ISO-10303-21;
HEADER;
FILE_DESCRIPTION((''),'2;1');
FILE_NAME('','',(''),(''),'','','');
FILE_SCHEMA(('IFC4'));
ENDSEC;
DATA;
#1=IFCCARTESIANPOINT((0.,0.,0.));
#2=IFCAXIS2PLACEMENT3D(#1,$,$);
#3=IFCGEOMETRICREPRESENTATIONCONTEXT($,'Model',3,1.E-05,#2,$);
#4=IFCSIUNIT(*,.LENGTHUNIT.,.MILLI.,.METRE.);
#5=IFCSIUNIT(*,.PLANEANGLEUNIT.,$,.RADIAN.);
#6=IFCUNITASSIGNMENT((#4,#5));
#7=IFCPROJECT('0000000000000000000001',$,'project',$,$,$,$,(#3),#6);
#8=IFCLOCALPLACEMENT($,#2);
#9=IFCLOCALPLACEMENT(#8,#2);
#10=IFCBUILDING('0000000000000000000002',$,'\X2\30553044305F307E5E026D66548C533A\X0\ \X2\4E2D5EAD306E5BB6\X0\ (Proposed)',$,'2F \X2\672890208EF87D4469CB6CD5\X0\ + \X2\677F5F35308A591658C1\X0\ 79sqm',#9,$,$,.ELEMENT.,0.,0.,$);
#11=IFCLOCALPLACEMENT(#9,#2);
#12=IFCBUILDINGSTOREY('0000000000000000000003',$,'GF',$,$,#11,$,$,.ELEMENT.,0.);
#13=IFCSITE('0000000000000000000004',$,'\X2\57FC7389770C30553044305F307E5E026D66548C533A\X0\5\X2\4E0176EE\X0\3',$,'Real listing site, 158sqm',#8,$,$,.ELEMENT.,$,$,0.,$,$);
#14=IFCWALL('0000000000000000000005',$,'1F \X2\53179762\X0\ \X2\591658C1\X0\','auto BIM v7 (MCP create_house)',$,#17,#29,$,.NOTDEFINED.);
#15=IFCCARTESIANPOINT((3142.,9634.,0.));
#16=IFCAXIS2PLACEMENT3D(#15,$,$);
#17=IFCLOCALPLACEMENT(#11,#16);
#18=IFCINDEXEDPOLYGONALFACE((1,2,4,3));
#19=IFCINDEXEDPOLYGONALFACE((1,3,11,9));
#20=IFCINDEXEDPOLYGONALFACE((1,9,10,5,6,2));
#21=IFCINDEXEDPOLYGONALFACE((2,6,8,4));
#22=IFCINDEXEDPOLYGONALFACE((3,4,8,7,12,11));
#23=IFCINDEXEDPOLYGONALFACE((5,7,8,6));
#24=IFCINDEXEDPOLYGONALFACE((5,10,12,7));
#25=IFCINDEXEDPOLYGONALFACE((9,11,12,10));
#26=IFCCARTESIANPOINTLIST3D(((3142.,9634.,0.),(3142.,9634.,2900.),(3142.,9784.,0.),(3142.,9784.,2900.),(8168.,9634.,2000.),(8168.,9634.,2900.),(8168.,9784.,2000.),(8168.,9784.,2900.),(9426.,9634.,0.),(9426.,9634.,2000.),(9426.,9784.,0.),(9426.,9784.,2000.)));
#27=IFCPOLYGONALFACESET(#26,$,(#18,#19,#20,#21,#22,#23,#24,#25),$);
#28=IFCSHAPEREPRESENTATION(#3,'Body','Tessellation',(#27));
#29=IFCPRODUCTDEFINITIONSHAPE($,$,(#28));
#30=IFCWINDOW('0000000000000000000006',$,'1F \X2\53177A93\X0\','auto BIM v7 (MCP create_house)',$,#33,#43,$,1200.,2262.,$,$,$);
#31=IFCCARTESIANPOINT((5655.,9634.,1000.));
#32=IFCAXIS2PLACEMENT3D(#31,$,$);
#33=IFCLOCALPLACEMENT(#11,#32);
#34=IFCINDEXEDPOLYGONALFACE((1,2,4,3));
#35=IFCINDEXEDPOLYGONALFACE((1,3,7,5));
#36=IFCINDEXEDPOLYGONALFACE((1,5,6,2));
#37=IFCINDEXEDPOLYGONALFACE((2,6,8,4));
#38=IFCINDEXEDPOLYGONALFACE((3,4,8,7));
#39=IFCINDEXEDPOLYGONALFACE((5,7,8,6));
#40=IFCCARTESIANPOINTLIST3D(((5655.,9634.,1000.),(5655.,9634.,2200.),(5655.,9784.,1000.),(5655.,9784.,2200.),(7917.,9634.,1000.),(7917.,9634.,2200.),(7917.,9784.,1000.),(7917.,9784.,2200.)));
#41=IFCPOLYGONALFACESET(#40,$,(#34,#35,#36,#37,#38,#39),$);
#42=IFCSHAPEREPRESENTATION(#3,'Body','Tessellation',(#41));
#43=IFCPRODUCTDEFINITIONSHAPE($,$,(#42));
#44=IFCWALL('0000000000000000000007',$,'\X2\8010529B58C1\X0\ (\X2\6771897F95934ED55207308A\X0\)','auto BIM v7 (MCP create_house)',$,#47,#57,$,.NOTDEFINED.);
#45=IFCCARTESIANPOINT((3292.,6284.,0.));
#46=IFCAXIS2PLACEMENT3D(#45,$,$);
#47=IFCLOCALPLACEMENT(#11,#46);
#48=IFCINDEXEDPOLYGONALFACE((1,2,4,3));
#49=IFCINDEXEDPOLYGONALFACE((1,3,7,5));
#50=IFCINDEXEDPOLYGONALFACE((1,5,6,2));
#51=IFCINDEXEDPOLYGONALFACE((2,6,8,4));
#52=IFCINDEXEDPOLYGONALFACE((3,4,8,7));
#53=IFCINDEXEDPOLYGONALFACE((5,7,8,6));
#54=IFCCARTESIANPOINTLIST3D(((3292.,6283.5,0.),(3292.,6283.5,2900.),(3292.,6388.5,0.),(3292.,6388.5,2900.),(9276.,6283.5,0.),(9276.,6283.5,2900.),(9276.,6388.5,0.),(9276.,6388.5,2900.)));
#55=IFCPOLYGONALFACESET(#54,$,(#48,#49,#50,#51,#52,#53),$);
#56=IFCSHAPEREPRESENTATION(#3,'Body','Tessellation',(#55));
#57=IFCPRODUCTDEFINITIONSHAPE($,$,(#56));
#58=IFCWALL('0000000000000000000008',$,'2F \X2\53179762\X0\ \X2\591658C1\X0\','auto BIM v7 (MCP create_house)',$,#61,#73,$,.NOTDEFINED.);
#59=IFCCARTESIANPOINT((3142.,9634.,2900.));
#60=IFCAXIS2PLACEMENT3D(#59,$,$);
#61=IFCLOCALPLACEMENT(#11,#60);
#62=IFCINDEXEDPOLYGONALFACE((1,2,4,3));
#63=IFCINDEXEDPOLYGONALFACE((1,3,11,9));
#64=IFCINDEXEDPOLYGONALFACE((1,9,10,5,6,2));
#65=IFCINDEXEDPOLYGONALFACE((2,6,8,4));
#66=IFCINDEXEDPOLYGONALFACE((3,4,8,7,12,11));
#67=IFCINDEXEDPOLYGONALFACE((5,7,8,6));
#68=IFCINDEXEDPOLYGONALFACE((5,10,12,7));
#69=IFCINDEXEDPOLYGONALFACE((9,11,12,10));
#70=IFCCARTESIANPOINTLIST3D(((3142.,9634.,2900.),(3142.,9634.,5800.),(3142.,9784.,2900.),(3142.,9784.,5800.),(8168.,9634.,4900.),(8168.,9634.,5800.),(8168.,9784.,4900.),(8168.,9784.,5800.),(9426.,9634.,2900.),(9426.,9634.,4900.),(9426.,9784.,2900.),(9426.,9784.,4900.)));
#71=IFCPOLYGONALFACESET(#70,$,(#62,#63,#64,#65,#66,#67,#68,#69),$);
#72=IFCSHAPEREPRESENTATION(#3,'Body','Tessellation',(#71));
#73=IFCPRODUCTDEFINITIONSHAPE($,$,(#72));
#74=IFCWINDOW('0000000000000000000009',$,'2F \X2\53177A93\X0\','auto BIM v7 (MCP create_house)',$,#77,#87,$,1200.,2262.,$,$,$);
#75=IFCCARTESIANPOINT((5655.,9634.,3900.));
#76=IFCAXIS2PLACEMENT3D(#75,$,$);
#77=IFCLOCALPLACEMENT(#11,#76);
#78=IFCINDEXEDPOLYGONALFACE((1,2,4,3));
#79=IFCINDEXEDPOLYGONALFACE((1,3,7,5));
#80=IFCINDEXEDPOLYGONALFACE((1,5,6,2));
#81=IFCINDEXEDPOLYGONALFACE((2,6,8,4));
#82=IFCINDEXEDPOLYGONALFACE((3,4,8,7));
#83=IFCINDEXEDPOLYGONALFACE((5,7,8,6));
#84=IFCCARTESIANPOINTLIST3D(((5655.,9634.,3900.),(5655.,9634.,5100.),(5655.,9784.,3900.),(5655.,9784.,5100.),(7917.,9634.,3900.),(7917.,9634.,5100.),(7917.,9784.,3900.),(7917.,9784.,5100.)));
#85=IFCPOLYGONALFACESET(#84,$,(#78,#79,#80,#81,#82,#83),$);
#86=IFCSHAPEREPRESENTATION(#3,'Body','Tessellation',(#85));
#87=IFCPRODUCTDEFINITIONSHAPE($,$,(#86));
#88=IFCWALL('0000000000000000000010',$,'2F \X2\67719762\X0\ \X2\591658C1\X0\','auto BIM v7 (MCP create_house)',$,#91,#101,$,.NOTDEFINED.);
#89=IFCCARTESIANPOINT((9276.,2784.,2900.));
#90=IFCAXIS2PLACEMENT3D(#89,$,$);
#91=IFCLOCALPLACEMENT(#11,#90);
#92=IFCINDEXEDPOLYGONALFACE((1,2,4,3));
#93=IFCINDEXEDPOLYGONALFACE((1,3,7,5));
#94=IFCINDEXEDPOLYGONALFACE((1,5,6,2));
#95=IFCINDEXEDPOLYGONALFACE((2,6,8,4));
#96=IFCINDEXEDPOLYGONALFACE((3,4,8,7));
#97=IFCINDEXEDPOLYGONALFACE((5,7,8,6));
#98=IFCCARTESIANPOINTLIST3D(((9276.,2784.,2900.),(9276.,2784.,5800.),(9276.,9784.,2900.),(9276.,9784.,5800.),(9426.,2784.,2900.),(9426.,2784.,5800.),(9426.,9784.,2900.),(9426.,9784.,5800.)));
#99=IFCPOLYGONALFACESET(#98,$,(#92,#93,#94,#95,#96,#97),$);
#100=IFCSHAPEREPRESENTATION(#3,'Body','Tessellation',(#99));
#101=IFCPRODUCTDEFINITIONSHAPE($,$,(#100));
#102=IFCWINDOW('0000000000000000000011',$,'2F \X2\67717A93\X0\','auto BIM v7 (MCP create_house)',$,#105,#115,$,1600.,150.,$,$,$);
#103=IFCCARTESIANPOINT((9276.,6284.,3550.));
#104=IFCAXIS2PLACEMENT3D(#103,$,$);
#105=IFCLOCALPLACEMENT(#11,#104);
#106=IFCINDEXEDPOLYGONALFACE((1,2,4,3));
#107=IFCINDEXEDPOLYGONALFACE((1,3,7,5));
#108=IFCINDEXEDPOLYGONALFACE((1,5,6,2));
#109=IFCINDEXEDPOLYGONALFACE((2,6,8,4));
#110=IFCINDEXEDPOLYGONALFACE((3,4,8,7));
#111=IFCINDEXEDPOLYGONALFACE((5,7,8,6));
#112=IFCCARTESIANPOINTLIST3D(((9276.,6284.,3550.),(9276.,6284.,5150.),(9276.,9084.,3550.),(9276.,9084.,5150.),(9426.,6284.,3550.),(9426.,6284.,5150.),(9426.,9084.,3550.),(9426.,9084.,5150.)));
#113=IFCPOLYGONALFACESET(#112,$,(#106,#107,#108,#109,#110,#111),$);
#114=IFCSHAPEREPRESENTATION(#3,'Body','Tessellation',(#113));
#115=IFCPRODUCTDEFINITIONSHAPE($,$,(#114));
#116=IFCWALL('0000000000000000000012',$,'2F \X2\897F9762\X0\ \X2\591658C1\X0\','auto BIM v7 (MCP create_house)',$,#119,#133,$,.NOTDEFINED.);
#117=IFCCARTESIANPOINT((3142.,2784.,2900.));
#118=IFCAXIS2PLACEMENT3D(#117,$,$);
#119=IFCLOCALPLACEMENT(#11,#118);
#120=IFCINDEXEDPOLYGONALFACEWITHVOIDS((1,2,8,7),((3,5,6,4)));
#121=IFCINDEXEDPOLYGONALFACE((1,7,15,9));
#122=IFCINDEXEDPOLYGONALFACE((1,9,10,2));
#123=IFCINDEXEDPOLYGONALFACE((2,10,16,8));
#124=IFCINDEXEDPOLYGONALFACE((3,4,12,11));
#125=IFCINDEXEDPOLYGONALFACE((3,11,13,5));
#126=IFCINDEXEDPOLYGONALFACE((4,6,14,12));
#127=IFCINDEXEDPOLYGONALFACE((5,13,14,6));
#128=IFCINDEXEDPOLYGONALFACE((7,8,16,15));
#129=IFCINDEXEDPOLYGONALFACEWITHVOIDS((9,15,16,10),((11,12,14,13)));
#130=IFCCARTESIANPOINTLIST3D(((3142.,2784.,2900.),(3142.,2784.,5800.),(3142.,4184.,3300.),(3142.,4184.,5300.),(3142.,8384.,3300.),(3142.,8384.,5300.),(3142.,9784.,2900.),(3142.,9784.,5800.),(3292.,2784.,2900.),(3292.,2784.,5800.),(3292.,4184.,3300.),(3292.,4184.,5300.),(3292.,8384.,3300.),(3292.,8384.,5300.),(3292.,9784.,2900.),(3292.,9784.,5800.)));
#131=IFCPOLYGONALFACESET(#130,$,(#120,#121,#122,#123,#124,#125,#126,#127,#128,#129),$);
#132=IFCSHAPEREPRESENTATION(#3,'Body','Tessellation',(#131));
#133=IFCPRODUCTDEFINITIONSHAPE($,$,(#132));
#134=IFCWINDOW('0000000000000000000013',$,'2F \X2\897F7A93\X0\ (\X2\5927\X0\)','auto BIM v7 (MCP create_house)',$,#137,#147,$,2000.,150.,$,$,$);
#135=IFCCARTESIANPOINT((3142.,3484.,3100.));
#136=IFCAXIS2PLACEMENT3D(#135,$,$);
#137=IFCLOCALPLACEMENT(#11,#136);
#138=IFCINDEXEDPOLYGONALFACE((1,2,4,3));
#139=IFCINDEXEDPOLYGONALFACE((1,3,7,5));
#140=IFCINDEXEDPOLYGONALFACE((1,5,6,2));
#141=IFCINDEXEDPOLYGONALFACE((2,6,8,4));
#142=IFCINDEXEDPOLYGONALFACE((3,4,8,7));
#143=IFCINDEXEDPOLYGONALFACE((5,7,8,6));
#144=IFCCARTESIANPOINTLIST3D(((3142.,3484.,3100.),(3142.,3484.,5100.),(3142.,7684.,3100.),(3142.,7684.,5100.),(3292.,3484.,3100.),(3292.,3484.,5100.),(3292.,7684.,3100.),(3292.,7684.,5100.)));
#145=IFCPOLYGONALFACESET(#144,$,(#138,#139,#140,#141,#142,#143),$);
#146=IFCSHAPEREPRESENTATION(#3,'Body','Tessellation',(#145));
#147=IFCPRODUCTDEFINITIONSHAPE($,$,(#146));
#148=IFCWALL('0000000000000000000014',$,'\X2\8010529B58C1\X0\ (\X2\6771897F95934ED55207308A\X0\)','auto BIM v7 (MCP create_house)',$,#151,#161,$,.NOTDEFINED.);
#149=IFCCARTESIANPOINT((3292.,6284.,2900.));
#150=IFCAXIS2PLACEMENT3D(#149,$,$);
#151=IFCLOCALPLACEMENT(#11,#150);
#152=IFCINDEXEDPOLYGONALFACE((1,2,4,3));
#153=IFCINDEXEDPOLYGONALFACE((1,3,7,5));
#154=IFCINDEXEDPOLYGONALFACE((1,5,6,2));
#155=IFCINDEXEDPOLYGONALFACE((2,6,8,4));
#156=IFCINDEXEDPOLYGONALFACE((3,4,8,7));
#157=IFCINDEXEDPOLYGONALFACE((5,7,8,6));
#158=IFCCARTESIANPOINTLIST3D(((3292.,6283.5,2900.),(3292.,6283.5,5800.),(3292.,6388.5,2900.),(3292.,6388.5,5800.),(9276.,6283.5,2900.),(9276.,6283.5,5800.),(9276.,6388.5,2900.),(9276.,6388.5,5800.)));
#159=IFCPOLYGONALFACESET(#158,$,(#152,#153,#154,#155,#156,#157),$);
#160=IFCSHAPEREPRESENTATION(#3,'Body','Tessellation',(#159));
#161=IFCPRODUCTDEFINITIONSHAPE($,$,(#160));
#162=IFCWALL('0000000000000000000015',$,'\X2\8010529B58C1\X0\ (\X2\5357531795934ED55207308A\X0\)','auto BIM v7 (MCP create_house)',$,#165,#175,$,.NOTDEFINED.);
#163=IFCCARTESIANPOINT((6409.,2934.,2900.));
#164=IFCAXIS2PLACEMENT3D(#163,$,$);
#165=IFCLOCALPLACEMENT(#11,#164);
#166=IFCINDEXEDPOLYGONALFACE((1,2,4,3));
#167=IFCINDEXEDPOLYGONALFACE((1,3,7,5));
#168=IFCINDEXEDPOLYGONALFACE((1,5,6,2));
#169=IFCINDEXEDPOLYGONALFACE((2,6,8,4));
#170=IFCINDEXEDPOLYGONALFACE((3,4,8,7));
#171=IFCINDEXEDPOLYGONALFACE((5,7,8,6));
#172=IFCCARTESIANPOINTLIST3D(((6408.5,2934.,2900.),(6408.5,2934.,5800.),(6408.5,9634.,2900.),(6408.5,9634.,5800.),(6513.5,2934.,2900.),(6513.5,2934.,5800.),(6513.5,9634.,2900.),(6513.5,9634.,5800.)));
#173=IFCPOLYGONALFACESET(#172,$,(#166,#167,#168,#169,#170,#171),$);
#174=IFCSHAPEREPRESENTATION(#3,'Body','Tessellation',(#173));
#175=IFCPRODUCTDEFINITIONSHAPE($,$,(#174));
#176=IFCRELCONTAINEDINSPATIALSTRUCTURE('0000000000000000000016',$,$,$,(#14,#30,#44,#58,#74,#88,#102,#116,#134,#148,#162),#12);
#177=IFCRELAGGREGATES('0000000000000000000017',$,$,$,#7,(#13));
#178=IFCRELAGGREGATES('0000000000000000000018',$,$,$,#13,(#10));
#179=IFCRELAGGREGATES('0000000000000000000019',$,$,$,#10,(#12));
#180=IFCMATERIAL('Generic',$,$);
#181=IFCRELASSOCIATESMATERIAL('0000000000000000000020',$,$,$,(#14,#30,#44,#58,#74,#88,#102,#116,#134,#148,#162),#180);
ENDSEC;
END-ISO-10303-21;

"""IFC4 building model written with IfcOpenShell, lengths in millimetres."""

from ifc_helpers import new_model, si_unit, frame, frame_2d, origin, place, context, project, spatial, rectangle, extrude, material, element, fill, save


model = new_model("IFC4")

# Units and contexts
model_context = context("Model", 3, precision=1e-05, world=origin())
ifc_project = project(units=[si_unit("LENGTHUNIT", "METRE", prefix="MILLI"), si_unit("PLANEANGLEUNIT", "RADIAN")], contexts=[model_context])

# Site, building, storey
site_placement = place(None, origin())
site = spatial("IfcSite", under=ifc_project, at=site_placement, Name="埼玉県さいたま市浦和区5丁目3", ObjectType="Real listing site, 158sqm", CompositionType="ELEMENT", RefElevation=0.0)
building_placement = place(site_placement, origin())
building = spatial("IfcBuilding", under=site, at=building_placement, Name="さいたま市浦和区 中庭の家 (Proposed)", ObjectType="2F 木造軸組構法 + 板張り外壁 79sqm", CompositionType="ELEMENT", ElevationOfRefHeight=0.0, ElevationOfTerrain=0.0)
storey_placement = place(building_placement, origin())
storey = spatial("IfcBuildingStorey", under=building, at=storey_placement, Name="GF", CompositionType="ELEMENT", Elevation=0.0)

# Wall, opening, window
ifc_material = material(Name="Generic")
wall_1_placement = place(storey_placement, frame((3142.0, 9634.0, 0.0)))
wall_1 = element("IfcWall", 1, at=wall_1_placement, inside=storey, material=ifc_material, Name="1F 北面 外壁", Description="auto BIM v7 (MCP create_house)", PredefinedType="NOTDEFINED", context=model_context, shape_type="SweptSolid", body=[
    extrude(rectangle(XDim=6284.0, YDim=150.0, at=frame_2d((3142.0, 75.0))), frame((3142.0, 9634.0, 0.0)), (0.0, 0.0, 1.0), 2900.0),
])
opening_1_placement = place(storey_placement, frame((5655.0, 9634.0, 1000.0)))
opening_1 = element("IfcOpeningElement", 2, at=opening_1_placement, cuts=wall_1, PredefinedType="NOTDEFINED", context=model_context, shape_type="SweptSolid", body=[
    extrude(rectangle(XDim=2262.0, YDim=150.0, at=frame_2d((1131.0, 75.0))), frame((5655.0, 9634.0, 1000.0)), (0.0, 0.0, 1.0), 1200.0),
])
window_1_placement = place(storey_placement, frame((5655.0, 9634.0, 1000.0)))
window_1 = element("IfcWindow", 3, at=window_1_placement, inside=storey, material=ifc_material, Name="1F 北窓", Description="auto BIM v7 (MCP create_house)", OverallHeight=1200.0, OverallWidth=2262.0, context=model_context, shape_type="SweptSolid", body=[
    extrude(rectangle(XDim=2262.0, YDim=150.0, at=frame_2d((1131.0, 75.0))), frame((5655.0, 9634.0, 1000.0)), (0.0, 0.0, 1.0), 1200.0),
])
fill(opening_1, window_1)

# Wall
wall_2_placement = place(storey_placement, frame((3292.0, 6284.0, 0.0)))
element("IfcWall", 4, at=wall_2_placement, inside=storey, material=ifc_material, Name="耐力壁 (東西間仕切り)", Description="auto BIM v7 (MCP create_house)", PredefinedType="NOTDEFINED", context=model_context, shape_type="SweptSolid", body=[
    extrude(rectangle(XDim=5984.0, YDim=105.0, at=frame_2d((2992.0, 52.0))), frame((3292.0, 6284.0, 0.0)), (0.0, 0.0, 1.0), 2900.0),
])

# Walls, openings, windows
wall_3_placement = place(storey_placement, frame((3142.0, 9634.0, 2900.0)))
wall_3 = element("IfcWall", 5, at=wall_3_placement, inside=storey, material=ifc_material, Name="2F 北面 外壁", Description="auto BIM v7 (MCP create_house)", PredefinedType="NOTDEFINED", context=model_context, shape_type="SweptSolid", body=[
    extrude(rectangle(XDim=6284.0, YDim=150.0, at=frame_2d((3142.0, 75.0))), frame((3142.0, 9634.0, 2900.0)), (0.0, 0.0, 1.0), 2900.0),
])
opening_2_placement = place(storey_placement, frame((5655.0, 9634.0, 3900.0)))
opening_2 = element("IfcOpeningElement", 6, at=opening_2_placement, cuts=wall_3, PredefinedType="NOTDEFINED", context=model_context, shape_type="SweptSolid", body=[
    extrude(rectangle(XDim=2262.0, YDim=150.0, at=frame_2d((1131.0, 75.0))), frame((5655.0, 9634.0, 3900.0)), (0.0, 0.0, 1.0), 1200.0),
])
window_2_placement = place(storey_placement, frame((5655.0, 9634.0, 3900.0)))
window_2 = element("IfcWindow", 7, at=window_2_placement, inside=storey, material=ifc_material, Name="2F 北窓", Description="auto BIM v7 (MCP create_house)", OverallHeight=1200.0, OverallWidth=2262.0, context=model_context, shape_type="SweptSolid", body=[
    extrude(rectangle(XDim=2262.0, YDim=150.0, at=frame_2d((1131.0, 75.0))), frame((5655.0, 9634.0, 3900.0)), (0.0, 0.0, 1.0), 1200.0),
])
fill(opening_2, window_2)
wall_4_placement = place(storey_placement, frame((9276.0, 2784.0, 2900.0)))
wall_4 = element("IfcWall", 8, at=wall_4_placement, inside=storey, material=ifc_material, Name="2F 東面 外壁", Description="auto BIM v7 (MCP create_house)", PredefinedType="NOTDEFINED", context=model_context, shape_type="SweptSolid", body=[
    extrude(rectangle(XDim=150.0, YDim=7000.0, at=frame_2d((75.0, 3500.0))), frame((9276.0, 2784.0, 2900.0)), (0.0, 0.0, 1.0), 2900.0),
])
opening_3_placement = place(storey_placement, frame((9276.0, 6284.0, 3550.0)))
opening_3 = element("IfcOpeningElement", 9, at=opening_3_placement, cuts=wall_4, PredefinedType="NOTDEFINED", context=model_context, shape_type="SweptSolid", body=[
    extrude(rectangle(XDim=150.0, YDim=2800.0, at=frame_2d((75.0, 1400.0))), frame((9276.0, 6284.0, 3550.0)), (0.0, 0.0, 1.0), 1600.0),
])
window_3_placement = place(storey_placement, frame((9276.0, 6284.0, 3550.0)))
window_3 = element("IfcWindow", 10, at=window_3_placement, inside=storey, material=ifc_material, Name="2F 東窓", Description="auto BIM v7 (MCP create_house)", OverallHeight=1600.0, OverallWidth=150.0, context=model_context, shape_type="SweptSolid", body=[
    extrude(rectangle(XDim=150.0, YDim=2800.0, at=frame_2d((75.0, 1400.0))), frame((9276.0, 6284.0, 3550.0)), (0.0, 0.0, 1.0), 1600.0),
])
fill(opening_3, window_3)
wall_5_placement = place(storey_placement, frame((3142.0, 2784.0, 2900.0)))
wall_5 = element("IfcWall", 11, at=wall_5_placement, inside=storey, material=ifc_material, Name="2F 西面 外壁", Description="auto BIM v7 (MCP create_house)", PredefinedType="NOTDEFINED", context=model_context, shape_type="SweptSolid", body=[
    extrude(rectangle(XDim=150.0, YDim=7000.0, at=frame_2d((75.0, 3500.0))), frame((3142.0, 2784.0, 2900.0)), (0.0, 0.0, 1.0), 2900.0),
])
opening_4_placement = place(storey_placement, frame((3142.0, 3484.0, 3100.0)))
opening_4 = element("IfcOpeningElement", 12, at=opening_4_placement, cuts=wall_5, PredefinedType="NOTDEFINED", context=model_context, shape_type="SweptSolid", body=[
    extrude(rectangle(XDim=150.0, YDim=4200.0, at=frame_2d((75.0, 2100.0))), frame((3142.0, 3484.0, 3100.0)), (0.0, 0.0, 1.0), 2000.0),
])
window_4_placement = place(storey_placement, frame((3142.0, 3484.0, 3100.0)))
window_4 = element("IfcWindow", 13, at=window_4_placement, inside=storey, material=ifc_material, Name="2F 西窓 (大)", Description="auto BIM v7 (MCP create_house)", OverallHeight=2000.0, OverallWidth=150.0, context=model_context, shape_type="SweptSolid", body=[
    extrude(rectangle(XDim=150.0, YDim=4200.0, at=frame_2d((75.0, 2100.0))), frame((3142.0, 3484.0, 3100.0)), (0.0, 0.0, 1.0), 2000.0),
])
fill(opening_4, window_4)

# Walls
wall_6_placement = place(storey_placement, frame((3292.0, 6284.0, 2900.0)))
element("IfcWall", 14, at=wall_6_placement, inside=storey, material=ifc_material, Name="耐力壁 (東西間仕切り)", Description="auto BIM v7 (MCP create_house)", PredefinedType="NOTDEFINED", context=model_context, shape_type="SweptSolid", body=[
    extrude(rectangle(XDim=5984.0, YDim=105.0, at=frame_2d((2992.0, 52.0))), frame((3292.0, 6284.0, 2900.0)), (0.0, 0.0, 1.0), 2900.0),
])
wall_7_placement = place(storey_placement, frame((6409.0, 2934.0, 2900.0)))
element("IfcWall", 15, at=wall_7_placement, inside=storey, material=ifc_material, Name="耐力壁 (南北間仕切り)", Description="auto BIM v7 (MCP create_house)", PredefinedType="NOTDEFINED", context=model_context, shape_type="SweptSolid", body=[
    extrude(rectangle(XDim=105.0, YDim=6700.0, at=frame_2d((52.0, 3350.0))), frame((6409.0, 2934.0, 2900.0)), (0.0, 0.0, 1.0), 2900.0),
])

save(model, "model.ifc")
